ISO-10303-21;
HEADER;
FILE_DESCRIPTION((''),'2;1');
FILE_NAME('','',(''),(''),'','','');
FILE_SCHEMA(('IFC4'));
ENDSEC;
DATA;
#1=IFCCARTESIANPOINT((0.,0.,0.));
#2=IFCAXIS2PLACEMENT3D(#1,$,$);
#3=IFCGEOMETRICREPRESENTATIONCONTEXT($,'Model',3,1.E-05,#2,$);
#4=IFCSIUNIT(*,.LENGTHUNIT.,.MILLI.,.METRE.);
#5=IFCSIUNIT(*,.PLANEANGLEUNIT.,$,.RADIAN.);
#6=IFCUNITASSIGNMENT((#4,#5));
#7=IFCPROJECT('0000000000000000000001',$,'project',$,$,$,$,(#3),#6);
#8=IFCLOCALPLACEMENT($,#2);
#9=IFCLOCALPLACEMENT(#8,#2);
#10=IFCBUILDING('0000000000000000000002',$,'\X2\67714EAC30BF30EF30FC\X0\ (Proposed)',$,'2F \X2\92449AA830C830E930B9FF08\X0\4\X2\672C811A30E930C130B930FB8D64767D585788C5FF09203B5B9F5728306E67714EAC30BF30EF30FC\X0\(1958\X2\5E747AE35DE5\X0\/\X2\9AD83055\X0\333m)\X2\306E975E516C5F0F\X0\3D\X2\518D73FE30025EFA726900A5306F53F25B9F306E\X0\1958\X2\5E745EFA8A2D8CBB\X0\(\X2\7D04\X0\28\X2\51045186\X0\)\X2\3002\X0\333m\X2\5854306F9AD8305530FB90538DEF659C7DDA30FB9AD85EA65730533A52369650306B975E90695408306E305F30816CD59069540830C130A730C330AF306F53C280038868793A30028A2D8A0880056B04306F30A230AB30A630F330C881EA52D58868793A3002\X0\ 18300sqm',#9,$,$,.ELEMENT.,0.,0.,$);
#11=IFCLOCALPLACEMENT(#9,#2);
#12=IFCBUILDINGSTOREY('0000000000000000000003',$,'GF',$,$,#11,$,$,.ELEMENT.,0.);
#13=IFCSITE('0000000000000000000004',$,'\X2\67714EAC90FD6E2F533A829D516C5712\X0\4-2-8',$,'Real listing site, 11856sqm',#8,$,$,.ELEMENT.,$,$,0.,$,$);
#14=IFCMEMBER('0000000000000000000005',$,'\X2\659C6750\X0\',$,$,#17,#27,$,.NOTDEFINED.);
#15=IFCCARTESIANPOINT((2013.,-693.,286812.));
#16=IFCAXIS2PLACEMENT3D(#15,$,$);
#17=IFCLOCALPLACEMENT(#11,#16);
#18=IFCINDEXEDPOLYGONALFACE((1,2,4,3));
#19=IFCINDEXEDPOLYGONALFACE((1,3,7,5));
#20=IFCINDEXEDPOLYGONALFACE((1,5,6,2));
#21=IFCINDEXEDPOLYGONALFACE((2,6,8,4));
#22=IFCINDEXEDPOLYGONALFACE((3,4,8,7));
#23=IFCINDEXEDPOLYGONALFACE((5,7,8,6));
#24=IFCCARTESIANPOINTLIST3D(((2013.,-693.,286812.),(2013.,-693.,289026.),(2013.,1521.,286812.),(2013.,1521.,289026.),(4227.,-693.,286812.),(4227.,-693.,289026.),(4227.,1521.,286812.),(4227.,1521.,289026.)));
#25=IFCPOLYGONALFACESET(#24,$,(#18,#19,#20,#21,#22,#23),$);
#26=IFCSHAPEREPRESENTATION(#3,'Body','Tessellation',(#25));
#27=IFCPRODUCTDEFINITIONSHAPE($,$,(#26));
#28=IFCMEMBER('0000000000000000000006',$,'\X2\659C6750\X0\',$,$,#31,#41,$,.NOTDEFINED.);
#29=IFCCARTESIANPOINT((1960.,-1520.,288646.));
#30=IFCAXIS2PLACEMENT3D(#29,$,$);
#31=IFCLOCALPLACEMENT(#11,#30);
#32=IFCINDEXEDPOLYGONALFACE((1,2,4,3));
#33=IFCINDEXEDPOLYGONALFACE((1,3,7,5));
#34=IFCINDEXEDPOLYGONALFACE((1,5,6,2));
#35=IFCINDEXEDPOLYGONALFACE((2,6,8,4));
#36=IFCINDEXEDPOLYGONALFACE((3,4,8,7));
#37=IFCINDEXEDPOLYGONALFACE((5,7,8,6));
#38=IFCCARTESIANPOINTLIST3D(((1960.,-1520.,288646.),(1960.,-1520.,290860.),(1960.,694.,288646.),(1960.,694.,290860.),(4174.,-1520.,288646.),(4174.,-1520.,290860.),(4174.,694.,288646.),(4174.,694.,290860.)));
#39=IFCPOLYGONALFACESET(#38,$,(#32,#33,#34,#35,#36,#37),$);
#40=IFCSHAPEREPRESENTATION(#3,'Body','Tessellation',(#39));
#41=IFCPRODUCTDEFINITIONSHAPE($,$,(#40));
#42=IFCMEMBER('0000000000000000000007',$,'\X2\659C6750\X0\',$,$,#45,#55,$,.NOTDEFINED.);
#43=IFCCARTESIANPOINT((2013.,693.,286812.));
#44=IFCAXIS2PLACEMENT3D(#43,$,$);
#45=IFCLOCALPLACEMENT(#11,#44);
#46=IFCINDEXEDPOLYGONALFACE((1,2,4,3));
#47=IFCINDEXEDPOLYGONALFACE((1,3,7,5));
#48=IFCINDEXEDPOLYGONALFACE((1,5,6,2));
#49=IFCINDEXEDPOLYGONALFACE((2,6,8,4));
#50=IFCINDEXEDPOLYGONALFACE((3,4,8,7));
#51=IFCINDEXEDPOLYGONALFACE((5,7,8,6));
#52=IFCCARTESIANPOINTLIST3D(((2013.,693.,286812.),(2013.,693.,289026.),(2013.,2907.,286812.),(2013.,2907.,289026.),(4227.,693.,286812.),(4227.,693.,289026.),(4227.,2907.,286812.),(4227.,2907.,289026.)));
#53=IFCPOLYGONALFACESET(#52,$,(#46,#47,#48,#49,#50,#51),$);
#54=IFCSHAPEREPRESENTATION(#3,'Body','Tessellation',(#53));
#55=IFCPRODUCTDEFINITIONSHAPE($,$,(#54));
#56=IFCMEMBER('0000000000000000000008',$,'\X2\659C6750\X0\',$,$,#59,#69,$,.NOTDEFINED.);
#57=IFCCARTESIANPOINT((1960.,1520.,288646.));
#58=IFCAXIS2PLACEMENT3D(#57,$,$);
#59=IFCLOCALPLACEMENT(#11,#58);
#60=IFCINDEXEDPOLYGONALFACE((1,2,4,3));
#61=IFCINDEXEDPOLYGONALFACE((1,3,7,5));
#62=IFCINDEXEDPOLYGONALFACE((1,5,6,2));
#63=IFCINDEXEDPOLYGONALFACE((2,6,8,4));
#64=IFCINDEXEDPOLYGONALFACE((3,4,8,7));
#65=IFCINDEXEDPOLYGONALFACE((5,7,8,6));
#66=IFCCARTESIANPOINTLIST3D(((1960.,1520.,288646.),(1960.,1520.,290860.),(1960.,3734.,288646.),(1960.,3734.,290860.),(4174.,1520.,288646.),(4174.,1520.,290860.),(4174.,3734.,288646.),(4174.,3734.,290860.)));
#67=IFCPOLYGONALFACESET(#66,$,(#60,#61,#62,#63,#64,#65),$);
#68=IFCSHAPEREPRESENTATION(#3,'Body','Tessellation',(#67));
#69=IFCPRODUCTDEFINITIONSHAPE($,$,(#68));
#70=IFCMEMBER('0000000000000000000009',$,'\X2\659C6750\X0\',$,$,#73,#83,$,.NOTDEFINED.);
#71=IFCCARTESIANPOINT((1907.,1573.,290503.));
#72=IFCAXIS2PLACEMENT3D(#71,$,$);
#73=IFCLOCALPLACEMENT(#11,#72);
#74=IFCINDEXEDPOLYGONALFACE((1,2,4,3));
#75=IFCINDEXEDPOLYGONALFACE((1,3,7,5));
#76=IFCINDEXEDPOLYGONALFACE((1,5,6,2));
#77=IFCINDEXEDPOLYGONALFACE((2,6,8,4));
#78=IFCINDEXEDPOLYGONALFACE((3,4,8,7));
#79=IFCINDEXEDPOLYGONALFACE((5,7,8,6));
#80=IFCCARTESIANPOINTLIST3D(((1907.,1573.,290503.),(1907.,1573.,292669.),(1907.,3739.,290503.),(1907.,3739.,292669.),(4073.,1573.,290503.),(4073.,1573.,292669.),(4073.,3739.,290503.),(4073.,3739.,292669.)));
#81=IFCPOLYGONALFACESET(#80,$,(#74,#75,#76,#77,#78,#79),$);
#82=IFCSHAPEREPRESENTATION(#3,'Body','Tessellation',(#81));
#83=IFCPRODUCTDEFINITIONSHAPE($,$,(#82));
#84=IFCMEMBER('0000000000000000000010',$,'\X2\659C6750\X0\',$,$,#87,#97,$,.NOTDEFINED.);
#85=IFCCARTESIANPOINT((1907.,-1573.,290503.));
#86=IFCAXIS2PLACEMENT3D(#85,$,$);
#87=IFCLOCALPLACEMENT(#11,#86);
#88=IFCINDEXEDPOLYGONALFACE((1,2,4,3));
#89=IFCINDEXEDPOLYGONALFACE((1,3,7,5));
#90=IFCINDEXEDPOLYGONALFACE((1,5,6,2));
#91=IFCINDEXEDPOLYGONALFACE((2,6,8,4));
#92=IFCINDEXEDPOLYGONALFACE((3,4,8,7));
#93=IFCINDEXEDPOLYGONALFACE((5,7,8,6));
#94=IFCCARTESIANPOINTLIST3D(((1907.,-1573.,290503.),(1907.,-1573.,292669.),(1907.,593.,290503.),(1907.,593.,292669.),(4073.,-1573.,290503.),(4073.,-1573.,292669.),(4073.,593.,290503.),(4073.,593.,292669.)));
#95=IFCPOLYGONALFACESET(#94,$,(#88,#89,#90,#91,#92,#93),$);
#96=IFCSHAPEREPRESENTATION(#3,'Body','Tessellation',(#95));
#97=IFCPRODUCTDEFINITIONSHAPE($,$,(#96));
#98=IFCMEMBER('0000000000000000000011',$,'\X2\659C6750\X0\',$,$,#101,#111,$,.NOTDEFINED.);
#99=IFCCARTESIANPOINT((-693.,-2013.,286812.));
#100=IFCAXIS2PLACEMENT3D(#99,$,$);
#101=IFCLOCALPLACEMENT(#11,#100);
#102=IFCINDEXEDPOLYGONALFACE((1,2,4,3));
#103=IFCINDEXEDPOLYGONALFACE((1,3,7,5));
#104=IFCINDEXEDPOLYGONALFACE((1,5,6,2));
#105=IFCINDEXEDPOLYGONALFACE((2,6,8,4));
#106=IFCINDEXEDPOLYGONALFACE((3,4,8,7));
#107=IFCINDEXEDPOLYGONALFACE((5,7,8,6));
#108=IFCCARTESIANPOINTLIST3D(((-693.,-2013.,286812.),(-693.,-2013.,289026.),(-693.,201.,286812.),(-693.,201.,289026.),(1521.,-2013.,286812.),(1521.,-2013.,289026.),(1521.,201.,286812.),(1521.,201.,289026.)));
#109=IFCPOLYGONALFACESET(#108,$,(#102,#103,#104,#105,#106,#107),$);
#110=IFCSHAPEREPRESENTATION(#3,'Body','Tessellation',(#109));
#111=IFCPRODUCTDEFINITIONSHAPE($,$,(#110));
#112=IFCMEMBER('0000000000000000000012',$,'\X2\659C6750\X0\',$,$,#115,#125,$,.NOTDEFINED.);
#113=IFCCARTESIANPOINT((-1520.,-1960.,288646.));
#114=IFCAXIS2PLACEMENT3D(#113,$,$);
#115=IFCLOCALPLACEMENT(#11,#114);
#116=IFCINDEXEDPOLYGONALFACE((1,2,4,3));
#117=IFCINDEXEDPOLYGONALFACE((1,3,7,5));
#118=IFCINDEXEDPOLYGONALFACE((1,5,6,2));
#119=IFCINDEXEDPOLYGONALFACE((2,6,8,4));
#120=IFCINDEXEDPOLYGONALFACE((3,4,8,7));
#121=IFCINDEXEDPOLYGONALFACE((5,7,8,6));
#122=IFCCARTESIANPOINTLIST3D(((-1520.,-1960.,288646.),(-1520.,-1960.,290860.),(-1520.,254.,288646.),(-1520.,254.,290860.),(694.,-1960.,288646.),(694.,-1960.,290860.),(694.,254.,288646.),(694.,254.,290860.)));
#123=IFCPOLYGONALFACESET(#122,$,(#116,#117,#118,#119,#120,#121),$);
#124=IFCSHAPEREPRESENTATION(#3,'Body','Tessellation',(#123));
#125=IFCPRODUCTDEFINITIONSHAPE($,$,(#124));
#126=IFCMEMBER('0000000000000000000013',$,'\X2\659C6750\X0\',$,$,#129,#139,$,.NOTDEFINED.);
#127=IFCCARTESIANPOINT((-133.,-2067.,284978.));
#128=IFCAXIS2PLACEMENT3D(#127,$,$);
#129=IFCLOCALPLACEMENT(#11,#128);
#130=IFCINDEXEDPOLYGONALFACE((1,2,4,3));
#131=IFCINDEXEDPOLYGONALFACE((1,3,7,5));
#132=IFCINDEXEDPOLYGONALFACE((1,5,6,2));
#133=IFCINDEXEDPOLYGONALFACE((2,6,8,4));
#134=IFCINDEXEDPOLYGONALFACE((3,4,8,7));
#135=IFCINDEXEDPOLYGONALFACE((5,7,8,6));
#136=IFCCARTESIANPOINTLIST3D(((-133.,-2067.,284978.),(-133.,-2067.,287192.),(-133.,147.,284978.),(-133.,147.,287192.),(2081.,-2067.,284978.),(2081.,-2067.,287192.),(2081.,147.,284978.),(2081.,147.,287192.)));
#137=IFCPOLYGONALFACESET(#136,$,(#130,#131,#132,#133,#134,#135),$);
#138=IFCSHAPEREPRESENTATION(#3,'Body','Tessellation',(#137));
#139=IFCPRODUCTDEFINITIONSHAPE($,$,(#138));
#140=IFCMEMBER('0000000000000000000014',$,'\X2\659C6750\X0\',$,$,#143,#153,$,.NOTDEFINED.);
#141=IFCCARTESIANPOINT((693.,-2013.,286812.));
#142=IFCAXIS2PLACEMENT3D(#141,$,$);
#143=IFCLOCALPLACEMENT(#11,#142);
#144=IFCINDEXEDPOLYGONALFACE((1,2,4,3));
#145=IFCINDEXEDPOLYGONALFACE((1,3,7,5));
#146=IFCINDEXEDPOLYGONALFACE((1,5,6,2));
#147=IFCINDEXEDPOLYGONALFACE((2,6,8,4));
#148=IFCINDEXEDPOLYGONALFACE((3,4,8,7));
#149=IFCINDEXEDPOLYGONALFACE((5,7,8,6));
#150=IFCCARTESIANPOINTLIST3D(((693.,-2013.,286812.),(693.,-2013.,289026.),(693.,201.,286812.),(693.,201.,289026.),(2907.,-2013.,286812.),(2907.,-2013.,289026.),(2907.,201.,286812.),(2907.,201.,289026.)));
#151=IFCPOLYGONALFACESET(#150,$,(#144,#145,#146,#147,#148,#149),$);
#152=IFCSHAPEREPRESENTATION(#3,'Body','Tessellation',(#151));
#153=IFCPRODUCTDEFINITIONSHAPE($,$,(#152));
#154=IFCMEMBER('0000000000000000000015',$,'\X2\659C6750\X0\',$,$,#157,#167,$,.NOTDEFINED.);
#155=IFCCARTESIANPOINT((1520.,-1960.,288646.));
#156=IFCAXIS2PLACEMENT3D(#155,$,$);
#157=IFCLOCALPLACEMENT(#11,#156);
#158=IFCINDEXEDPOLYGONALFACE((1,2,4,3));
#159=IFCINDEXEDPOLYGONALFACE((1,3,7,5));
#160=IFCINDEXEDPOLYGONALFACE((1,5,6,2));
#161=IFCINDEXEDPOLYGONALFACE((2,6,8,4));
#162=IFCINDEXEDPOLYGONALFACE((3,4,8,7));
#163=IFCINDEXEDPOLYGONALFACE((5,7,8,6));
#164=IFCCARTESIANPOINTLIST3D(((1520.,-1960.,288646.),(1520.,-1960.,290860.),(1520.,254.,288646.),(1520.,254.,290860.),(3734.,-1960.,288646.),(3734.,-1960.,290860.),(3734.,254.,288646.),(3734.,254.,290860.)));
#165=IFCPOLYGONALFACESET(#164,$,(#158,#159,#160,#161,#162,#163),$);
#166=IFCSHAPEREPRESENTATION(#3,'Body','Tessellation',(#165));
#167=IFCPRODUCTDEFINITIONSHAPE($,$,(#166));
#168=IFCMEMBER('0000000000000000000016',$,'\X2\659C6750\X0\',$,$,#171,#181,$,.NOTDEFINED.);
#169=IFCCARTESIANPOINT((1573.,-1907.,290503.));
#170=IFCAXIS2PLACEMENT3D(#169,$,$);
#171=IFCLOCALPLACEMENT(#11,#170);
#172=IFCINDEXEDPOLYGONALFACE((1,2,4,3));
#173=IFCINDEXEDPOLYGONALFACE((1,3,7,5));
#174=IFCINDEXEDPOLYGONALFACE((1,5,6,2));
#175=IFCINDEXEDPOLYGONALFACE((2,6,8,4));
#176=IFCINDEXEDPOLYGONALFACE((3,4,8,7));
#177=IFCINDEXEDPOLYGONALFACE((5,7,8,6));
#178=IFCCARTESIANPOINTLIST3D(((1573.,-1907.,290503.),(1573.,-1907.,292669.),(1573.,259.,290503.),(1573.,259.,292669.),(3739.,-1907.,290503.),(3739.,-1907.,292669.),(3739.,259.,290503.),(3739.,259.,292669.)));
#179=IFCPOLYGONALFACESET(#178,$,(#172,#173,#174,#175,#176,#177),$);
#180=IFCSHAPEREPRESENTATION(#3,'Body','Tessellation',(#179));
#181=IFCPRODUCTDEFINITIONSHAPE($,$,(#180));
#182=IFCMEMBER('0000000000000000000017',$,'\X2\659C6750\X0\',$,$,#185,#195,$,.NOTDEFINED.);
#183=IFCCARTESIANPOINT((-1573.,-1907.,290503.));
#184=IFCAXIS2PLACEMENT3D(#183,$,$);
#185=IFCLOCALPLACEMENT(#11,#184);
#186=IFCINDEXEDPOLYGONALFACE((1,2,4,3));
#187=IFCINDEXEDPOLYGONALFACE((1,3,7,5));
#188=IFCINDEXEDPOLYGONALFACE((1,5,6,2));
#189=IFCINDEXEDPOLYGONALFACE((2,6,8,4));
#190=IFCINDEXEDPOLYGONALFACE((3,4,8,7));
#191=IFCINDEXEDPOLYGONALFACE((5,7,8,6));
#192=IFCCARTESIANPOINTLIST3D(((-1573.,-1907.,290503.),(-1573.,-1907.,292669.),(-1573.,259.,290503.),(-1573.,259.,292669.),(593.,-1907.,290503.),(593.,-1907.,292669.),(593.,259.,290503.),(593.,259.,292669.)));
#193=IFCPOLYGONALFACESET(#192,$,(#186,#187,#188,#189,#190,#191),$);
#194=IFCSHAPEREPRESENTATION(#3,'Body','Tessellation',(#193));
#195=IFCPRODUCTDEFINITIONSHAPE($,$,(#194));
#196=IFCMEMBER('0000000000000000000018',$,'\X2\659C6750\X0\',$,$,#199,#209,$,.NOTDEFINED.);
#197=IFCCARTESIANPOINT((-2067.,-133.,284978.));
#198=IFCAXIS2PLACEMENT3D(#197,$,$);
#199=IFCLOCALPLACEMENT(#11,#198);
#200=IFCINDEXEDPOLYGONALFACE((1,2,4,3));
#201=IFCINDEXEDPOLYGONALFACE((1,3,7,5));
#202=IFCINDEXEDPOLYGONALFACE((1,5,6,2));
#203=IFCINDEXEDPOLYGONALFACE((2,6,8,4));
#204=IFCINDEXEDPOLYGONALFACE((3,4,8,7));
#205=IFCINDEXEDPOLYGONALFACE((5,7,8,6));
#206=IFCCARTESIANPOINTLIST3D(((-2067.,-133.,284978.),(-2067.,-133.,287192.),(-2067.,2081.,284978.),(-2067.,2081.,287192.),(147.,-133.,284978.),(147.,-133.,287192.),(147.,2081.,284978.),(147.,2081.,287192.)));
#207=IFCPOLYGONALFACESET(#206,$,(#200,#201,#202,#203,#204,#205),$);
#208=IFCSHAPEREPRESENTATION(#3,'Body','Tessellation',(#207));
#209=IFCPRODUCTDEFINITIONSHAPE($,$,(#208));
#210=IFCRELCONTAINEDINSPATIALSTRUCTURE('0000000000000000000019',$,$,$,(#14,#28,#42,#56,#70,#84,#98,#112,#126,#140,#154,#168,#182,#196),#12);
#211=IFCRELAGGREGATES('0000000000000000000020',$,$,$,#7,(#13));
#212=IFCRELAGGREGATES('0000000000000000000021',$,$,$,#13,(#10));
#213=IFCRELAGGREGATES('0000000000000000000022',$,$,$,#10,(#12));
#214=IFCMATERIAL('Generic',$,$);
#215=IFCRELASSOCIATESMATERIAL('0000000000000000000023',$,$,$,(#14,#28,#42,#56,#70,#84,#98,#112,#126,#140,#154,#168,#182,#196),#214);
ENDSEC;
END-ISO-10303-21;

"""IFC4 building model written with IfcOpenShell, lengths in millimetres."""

from ifc_helpers import new_model, si_unit, frame, frame_2d, origin, place, context, project, spatial, rectangle, extrude, material, element, save


model = new_model("IFC4")

# Units and contexts
model_context = context("Model", 3, precision=1e-05, world=origin())
ifc_project = project(units=[si_unit("LENGTHUNIT", "METRE", prefix="MILLI"), si_unit("PLANEANGLEUNIT", "RADIAN")], contexts=[model_context])

# Site, building, storey
site_placement = place(None, origin())
site = spatial("IfcSite", under=ifc_project, at=site_placement, Name="東京都港区芝公園4-2-8", ObjectType="Real listing site, 11856sqm", CompositionType="ELEMENT", RefElevation=0.0)
building_placement = place(site_placement, origin())
building = spatial("IfcBuilding", under=site, at=building_placement, Name="東京タワー (Proposed)", ObjectType="2F 鉄骨トラス（4本脚ラチス・赤白塗装）※実在の東京タワー(1958年竣工/高さ333m)の非公式3D再現。建物¥は史実の1958年建設費(約28億円)。333m塔は高さ・道路斜線・高度地区制限に非適合のため法適合チェックは参考表示。設計者欄はアカウント自動表示。 18300sqm", CompositionType="ELEMENT", ElevationOfRefHeight=0.0, ElevationOfTerrain=0.0)
storey_placement = place(building_placement, origin())
storey = spatial("IfcBuildingStorey", under=building, at=storey_placement, Name="GF", CompositionType="ELEMENT", Elevation=0.0)

# Members
ifc_material = material(Name="Generic")
member_1_placement = place(storey_placement, frame((2013.0, -693.0, 286812.0)))
element("IfcMember", 1, at=member_1_placement, inside=storey, material=ifc_material, Name="斜材", PredefinedType="NOTDEFINED", context=model_context, shape_type="SweptSolid", body=[
    extrude(rectangle(XDim=2214.0, YDim=2214.0, at=frame_2d((1107.0, 1107.0))), frame((2013.0, -693.0, 286812.0)), (0.0, 0.0, 1.0), 2214.0),
])
member_2_placement = place(storey_placement, frame((1960.0, -1520.0, 288646.0)))
element("IfcMember", 2, at=member_2_placement, inside=storey, material=ifc_material, Name="斜材", PredefinedType="NOTDEFINED", context=model_context, shape_type="SweptSolid", body=[
    extrude(rectangle(XDim=2214.0, YDim=2214.0, at=frame_2d((1107.0, 1107.0))), frame((1960.0, -1520.0, 288646.0)), (0.0, 0.0, 1.0), 2214.0),
])
member_3_placement = place(storey_placement, frame((2013.0, 693.0, 286812.0)))
element("IfcMember", 3, at=member_3_placement, inside=storey, material=ifc_material, Name="斜材", PredefinedType="NOTDEFINED", context=model_context, shape_type="SweptSolid", body=[
    extrude(rectangle(XDim=2214.0, YDim=2214.0, at=frame_2d((1107.0, 1107.0))), frame((2013.0, 693.0, 286812.0)), (0.0, 0.0, 1.0), 2214.0),
])
member_4_placement = place(storey_placement, frame((1960.0, 1520.0, 288646.0)))
element("IfcMember", 4, at=member_4_placement, inside=storey, material=ifc_material, Name="斜材", PredefinedType="NOTDEFINED", context=model_context, shape_type="SweptSolid", body=[
    extrude(rectangle(XDim=2214.0, YDim=2214.0, at=frame_2d((1107.0, 1107.0))), frame((1960.0, 1520.0, 288646.0)), (0.0, 0.0, 1.0), 2214.0),
])
member_5_placement = place(storey_placement, frame((1907.0, 1573.0, 290503.0)))
element("IfcMember", 5, at=member_5_placement, inside=storey, material=ifc_material, Name="斜材", PredefinedType="NOTDEFINED", context=model_context, shape_type="SweptSolid", body=[
    extrude(rectangle(XDim=2166.0, YDim=2166.0, at=frame_2d((1083.0, 1083.0))), frame((1907.0, 1573.0, 290503.0)), (0.0, 0.0, 1.0), 2166.0),
])
member_6_placement = place(storey_placement, frame((1907.0, -1573.0, 290503.0)))
element("IfcMember", 6, at=member_6_placement, inside=storey, material=ifc_material, Name="斜材", PredefinedType="NOTDEFINED", context=model_context, shape_type="SweptSolid", body=[
    extrude(rectangle(XDim=2166.0, YDim=2166.0, at=frame_2d((1083.0, 1083.0))), frame((1907.0, -1573.0, 290503.0)), (0.0, 0.0, 1.0), 2166.0),
])
member_7_placement = place(storey_placement, frame((-693.0, -2013.0, 286812.0)))
element("IfcMember", 7, at=member_7_placement, inside=storey, material=ifc_material, Name="斜材", PredefinedType="NOTDEFINED", context=model_context, shape_type="SweptSolid", body=[
    extrude(rectangle(XDim=2214.0, YDim=2214.0, at=frame_2d((1107.0, 1107.0))), frame((-693.0, -2013.0, 286812.0)), (0.0, 0.0, 1.0), 2214.0),
])
member_8_placement = place(storey_placement, frame((-1520.0, -1960.0, 288646.0)))
element("IfcMember", 8, at=member_8_placement, inside=storey, material=ifc_material, Name="斜材", PredefinedType="NOTDEFINED", context=model_context, shape_type="SweptSolid", body=[
    extrude(rectangle(XDim=2214.0, YDim=2214.0, at=frame_2d((1107.0, 1107.0))), frame((-1520.0, -1960.0, 288646.0)), (0.0, 0.0, 1.0), 2214.0),
])
member_9_placement = place(storey_placement, frame((-133.0, -2067.0, 284978.0)))
element("IfcMember", 9, at=member_9_placement, inside=storey, material=ifc_material, Name="斜材", PredefinedType="NOTDEFINED", context=model_context, shape_type="SweptSolid", body=[
    extrude(rectangle(XDim=2214.0, YDim=2214.0, at=frame_2d((1107.0, 1107.0))), frame((-133.0, -2067.0, 284978.0)), (0.0, 0.0, 1.0), 2214.0),
])
member_10_placement = place(storey_placement, frame((693.0, -2013.0, 286812.0)))
element("IfcMember", 10, at=member_10_placement, inside=storey, material=ifc_material, Name="斜材", PredefinedType="NOTDEFINED", context=model_context, shape_type="SweptSolid", body=[
    extrude(rectangle(XDim=2214.0, YDim=2214.0, at=frame_2d((1107.0, 1107.0))), frame((693.0, -2013.0, 286812.0)), (0.0, 0.0, 1.0), 2214.0),
])
member_11_placement = place(storey_placement, frame((1520.0, -1960.0, 288646.0)))
element("IfcMember", 11, at=member_11_placement, inside=storey, material=ifc_material, Name="斜材", PredefinedType="NOTDEFINED", context=model_context, shape_type="SweptSolid", body=[
    extrude(rectangle(XDim=2214.0, YDim=2214.0, at=frame_2d((1107.0, 1107.0))), frame((1520.0, -1960.0, 288646.0)), (0.0, 0.0, 1.0), 2214.0),
])
member_12_placement = place(storey_placement, frame((1573.0, -1907.0, 290503.0)))
element("IfcMember", 12, at=member_12_placement, inside=storey, material=ifc_material, Name="斜材", PredefinedType="NOTDEFINED", context=model_context, shape_type="SweptSolid", body=[
    extrude(rectangle(XDim=2166.0, YDim=2166.0, at=frame_2d((1083.0, 1083.0))), frame((1573.0, -1907.0, 290503.0)), (0.0, 0.0, 1.0), 2166.0),
])
member_13_placement = place(storey_placement, frame((-1573.0, -1907.0, 290503.0)))
element("IfcMember", 13, at=member_13_placement, inside=storey, material=ifc_material, Name="斜材", PredefinedType="NOTDEFINED", context=model_context, shape_type="SweptSolid", body=[
    extrude(rectangle(XDim=2166.0, YDim=2166.0, at=frame_2d((1083.0, 1083.0))), frame((-1573.0, -1907.0, 290503.0)), (0.0, 0.0, 1.0), 2166.0),
])
member_14_placement = place(storey_placement, frame((-2067.0, -133.0, 284978.0)))
element("IfcMember", 14, at=member_14_placement, inside=storey, material=ifc_material, Name="斜材", PredefinedType="NOTDEFINED", context=model_context, shape_type="SweptSolid", body=[
    extrude(rectangle(XDim=2214.0, YDim=2214.0, at=frame_2d((1107.0, 1107.0))), frame((-2067.0, -133.0, 284978.0)), (0.0, 0.0, 1.0), 2214.0),
])

save(model, "model.ifc")
